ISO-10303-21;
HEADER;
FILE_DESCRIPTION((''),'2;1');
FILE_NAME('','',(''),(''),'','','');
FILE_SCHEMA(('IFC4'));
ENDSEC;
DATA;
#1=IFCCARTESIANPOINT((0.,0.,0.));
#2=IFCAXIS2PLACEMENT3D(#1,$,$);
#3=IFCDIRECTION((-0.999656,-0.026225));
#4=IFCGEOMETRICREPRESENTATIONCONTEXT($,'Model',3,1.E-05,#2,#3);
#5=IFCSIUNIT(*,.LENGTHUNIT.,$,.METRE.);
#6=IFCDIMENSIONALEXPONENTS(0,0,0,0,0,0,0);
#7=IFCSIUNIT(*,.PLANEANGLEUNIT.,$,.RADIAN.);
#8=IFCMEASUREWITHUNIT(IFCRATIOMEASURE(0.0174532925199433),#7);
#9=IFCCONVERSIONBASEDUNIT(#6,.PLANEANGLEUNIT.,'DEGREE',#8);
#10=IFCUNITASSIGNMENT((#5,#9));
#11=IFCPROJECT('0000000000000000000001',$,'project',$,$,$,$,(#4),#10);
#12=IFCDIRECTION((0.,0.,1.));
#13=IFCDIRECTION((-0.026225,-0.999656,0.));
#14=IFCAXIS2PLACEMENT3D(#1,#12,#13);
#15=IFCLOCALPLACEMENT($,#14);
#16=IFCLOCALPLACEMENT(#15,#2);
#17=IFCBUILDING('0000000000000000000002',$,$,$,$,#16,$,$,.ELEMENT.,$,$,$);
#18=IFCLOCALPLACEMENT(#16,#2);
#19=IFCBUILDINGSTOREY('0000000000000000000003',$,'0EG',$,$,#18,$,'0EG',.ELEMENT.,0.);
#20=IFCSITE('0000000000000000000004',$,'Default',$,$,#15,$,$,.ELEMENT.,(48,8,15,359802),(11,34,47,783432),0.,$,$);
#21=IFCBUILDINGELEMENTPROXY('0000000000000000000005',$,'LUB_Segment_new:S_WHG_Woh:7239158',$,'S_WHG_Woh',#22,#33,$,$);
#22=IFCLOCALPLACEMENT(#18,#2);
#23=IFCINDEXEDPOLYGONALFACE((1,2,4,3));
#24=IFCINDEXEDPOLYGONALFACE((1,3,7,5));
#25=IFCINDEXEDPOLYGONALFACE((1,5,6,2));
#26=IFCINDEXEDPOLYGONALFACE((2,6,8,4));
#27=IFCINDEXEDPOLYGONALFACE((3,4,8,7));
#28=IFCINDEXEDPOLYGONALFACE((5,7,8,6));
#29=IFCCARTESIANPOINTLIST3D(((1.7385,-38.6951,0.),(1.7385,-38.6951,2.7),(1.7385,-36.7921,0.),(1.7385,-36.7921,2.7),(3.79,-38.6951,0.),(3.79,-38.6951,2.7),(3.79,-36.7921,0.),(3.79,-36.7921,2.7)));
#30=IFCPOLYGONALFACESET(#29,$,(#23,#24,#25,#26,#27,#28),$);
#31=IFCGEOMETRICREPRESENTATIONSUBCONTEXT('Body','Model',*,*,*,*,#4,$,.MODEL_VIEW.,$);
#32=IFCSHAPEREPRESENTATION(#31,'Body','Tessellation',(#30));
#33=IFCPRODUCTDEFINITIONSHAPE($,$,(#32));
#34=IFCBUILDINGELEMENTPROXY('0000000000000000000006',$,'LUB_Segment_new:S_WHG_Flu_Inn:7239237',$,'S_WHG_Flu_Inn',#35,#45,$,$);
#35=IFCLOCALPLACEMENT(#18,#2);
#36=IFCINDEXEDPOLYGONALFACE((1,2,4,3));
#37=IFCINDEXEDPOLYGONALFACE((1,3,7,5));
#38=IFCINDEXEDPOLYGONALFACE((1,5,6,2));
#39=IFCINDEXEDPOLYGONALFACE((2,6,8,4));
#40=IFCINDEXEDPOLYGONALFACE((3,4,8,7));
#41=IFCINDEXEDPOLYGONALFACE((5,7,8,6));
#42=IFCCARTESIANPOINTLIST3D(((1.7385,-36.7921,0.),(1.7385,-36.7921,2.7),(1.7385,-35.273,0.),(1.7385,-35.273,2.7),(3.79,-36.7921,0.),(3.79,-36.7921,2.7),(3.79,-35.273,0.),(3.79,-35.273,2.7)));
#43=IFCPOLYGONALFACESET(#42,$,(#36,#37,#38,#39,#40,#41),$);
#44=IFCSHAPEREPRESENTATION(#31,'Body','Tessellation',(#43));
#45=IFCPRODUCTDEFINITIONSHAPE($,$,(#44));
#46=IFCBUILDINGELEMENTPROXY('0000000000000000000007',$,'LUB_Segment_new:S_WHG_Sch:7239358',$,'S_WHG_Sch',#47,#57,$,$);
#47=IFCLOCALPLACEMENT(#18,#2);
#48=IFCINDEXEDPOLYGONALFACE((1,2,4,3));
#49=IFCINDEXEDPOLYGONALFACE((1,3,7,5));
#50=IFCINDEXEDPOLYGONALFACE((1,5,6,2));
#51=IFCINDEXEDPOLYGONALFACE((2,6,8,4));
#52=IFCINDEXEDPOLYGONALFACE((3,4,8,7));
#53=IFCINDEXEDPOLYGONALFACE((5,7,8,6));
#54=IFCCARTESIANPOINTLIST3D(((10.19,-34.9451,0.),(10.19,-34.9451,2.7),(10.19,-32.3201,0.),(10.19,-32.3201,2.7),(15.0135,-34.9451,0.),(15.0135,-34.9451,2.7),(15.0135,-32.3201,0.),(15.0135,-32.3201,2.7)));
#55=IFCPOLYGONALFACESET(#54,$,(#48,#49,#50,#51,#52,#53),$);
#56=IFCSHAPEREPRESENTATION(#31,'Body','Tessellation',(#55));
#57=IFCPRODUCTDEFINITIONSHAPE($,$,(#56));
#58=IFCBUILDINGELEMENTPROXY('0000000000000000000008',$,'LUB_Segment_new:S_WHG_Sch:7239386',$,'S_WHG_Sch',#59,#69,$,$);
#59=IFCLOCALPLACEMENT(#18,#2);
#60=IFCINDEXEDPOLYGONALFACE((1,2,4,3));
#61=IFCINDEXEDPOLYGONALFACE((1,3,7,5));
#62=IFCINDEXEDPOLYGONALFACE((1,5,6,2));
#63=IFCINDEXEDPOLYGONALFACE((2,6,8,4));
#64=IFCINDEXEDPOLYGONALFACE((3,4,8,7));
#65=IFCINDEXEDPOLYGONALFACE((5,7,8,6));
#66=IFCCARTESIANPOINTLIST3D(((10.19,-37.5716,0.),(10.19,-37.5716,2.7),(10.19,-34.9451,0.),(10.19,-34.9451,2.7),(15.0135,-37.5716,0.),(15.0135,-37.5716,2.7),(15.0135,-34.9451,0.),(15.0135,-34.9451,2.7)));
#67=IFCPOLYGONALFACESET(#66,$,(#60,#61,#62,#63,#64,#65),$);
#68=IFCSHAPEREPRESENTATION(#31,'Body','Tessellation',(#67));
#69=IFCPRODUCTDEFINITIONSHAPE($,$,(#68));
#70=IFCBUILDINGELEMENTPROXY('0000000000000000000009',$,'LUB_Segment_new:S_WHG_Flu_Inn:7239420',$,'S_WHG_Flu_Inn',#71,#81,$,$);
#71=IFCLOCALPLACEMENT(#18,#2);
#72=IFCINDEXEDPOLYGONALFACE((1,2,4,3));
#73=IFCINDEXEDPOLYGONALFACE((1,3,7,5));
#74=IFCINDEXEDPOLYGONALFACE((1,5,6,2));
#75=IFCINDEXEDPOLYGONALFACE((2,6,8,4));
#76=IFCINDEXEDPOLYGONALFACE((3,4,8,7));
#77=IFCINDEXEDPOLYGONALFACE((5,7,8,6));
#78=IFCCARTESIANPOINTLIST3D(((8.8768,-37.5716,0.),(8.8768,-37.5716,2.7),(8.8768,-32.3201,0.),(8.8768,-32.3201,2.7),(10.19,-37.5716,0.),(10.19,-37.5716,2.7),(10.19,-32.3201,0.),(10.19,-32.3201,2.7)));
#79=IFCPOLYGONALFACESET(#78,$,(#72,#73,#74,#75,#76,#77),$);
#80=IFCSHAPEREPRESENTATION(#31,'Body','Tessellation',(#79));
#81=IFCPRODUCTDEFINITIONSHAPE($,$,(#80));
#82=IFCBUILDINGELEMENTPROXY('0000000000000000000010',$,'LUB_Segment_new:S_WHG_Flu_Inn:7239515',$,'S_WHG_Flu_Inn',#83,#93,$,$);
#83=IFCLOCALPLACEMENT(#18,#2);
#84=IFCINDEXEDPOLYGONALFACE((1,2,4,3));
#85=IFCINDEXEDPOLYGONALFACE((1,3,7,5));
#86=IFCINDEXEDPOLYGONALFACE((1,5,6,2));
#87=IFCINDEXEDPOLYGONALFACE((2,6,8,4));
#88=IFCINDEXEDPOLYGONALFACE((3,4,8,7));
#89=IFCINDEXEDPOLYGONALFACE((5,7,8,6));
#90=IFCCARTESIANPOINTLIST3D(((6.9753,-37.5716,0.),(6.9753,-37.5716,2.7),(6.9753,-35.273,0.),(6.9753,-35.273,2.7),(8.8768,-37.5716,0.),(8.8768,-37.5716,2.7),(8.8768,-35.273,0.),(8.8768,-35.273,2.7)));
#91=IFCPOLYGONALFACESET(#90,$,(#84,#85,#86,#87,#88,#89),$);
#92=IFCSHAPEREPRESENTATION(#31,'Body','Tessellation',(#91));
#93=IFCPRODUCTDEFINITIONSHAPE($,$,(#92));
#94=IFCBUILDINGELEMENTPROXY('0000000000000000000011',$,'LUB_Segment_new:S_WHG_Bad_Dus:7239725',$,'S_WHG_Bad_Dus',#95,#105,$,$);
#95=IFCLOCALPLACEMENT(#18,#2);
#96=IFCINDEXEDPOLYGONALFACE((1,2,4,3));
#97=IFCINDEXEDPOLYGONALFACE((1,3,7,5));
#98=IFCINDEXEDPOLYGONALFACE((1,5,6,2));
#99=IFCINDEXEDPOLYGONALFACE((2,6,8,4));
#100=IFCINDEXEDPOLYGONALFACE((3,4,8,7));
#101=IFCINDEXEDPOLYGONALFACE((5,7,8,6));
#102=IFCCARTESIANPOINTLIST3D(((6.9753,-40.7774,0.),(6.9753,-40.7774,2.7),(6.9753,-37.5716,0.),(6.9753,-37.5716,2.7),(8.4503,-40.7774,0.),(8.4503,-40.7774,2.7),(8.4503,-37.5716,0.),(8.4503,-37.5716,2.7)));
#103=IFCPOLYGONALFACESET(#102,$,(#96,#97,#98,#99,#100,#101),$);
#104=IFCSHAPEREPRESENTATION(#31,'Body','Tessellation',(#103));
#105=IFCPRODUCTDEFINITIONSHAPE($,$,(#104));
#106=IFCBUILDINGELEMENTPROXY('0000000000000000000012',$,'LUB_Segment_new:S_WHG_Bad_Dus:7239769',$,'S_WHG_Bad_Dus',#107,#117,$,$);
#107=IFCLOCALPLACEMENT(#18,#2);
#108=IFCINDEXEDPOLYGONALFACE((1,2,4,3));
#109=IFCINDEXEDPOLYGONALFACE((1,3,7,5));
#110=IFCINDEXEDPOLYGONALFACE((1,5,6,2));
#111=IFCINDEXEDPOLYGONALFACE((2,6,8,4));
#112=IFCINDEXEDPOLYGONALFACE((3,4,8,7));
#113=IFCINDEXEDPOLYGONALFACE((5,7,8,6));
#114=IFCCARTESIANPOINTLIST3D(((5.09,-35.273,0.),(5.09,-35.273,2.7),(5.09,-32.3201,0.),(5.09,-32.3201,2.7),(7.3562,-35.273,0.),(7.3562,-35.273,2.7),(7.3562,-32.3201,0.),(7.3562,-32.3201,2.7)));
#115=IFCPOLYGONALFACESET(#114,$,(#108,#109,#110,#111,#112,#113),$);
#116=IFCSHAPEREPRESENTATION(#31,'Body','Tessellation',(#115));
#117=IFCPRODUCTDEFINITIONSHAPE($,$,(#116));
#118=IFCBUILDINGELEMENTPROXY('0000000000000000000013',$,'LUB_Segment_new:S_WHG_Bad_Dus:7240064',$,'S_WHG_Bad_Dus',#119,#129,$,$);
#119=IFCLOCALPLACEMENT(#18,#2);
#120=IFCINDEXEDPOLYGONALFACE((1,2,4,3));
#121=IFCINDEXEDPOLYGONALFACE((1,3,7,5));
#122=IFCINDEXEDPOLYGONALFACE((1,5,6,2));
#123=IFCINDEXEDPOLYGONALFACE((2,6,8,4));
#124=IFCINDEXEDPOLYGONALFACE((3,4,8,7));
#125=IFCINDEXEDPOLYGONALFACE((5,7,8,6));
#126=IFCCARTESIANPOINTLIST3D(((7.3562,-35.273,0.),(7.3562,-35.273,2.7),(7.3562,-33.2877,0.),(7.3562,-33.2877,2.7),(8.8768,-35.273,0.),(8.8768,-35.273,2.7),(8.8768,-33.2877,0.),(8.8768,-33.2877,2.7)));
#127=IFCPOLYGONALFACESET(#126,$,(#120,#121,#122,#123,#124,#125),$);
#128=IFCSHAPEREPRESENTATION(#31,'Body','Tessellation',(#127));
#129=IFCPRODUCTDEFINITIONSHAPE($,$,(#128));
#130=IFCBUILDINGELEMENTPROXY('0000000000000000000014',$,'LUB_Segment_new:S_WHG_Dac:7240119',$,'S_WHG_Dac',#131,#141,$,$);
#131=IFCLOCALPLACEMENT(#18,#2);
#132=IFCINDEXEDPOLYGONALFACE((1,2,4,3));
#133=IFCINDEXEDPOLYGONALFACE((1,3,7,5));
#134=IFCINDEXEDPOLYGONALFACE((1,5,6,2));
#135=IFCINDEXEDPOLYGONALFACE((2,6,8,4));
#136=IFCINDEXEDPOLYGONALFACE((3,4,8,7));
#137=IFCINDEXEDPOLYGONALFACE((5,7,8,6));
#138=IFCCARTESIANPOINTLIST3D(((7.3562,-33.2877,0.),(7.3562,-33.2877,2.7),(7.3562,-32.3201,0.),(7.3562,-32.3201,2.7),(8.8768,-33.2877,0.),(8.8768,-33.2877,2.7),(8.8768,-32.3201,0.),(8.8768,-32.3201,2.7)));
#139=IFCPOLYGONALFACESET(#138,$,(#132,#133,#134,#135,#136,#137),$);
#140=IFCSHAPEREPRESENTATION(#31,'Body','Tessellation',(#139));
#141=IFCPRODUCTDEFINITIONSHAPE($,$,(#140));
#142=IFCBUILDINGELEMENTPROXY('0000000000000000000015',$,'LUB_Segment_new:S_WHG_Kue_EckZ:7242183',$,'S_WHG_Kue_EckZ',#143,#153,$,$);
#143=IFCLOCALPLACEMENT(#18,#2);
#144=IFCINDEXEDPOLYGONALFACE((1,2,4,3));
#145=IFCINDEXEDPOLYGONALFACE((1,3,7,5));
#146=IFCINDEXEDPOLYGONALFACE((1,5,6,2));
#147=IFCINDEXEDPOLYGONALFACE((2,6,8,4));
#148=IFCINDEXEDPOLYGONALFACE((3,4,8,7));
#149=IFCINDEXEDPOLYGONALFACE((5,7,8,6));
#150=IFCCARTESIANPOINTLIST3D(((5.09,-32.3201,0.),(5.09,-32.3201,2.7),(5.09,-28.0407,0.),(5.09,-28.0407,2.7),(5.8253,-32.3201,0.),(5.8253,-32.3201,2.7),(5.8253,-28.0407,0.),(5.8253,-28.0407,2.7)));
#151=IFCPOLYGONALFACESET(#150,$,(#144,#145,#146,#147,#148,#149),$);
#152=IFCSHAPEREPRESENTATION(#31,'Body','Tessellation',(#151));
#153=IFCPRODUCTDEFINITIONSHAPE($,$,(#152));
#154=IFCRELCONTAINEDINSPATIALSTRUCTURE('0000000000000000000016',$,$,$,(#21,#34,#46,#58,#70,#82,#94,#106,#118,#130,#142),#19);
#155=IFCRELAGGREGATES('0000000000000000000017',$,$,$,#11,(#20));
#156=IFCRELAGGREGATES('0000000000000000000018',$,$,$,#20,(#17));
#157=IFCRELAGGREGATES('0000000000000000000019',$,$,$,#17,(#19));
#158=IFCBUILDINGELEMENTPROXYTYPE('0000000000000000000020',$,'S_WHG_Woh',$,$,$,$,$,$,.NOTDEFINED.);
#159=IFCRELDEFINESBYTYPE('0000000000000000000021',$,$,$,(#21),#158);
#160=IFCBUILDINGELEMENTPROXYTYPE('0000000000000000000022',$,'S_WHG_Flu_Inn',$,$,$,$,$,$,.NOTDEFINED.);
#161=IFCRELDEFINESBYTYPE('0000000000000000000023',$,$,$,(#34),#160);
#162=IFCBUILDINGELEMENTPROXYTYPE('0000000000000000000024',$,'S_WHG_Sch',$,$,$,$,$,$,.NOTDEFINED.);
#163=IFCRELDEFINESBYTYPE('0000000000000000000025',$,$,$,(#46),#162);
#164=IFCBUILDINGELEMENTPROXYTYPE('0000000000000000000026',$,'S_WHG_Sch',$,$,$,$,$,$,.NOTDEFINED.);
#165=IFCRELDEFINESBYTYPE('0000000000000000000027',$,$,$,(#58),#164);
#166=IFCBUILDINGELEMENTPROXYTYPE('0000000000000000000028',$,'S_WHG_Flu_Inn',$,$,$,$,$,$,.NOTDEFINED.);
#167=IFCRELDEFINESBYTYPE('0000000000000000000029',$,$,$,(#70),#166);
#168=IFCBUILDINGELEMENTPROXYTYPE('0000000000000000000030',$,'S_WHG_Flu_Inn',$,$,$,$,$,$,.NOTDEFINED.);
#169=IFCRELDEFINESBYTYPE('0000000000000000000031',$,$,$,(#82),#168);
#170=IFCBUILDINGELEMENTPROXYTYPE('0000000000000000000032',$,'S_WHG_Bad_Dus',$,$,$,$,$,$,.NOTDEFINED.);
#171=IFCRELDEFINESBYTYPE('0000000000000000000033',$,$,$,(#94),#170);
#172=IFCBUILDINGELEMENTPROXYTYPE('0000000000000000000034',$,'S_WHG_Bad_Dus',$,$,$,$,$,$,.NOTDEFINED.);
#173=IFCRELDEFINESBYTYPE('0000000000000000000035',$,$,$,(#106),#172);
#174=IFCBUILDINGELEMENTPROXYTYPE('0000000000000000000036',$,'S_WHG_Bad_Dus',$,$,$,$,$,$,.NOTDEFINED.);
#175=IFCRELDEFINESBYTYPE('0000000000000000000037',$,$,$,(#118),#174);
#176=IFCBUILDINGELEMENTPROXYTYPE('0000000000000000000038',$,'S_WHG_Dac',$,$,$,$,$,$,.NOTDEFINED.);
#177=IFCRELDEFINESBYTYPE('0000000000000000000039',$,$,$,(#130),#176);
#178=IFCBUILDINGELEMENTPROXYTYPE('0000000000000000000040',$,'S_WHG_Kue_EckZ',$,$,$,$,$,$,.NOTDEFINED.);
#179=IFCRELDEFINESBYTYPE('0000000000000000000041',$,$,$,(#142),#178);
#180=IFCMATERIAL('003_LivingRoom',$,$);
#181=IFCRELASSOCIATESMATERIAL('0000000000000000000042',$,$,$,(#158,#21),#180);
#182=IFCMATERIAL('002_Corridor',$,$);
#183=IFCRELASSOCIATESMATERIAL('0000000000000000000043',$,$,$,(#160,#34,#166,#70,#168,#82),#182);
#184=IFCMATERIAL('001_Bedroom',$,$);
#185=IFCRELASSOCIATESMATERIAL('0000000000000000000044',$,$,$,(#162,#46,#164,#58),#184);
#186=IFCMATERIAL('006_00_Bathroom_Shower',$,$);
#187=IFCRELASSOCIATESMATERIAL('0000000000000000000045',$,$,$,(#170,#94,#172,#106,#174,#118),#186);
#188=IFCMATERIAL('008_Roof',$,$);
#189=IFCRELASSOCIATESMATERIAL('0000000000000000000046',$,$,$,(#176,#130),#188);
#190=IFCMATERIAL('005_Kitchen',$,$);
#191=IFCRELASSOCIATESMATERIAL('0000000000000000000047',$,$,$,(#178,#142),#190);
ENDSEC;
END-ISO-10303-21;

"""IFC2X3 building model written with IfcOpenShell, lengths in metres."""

from ifc_helpers import new_model, entity, si_unit, converted_unit, direction, frame, frame_2d, origin, origin_2d_with_axis, place, context, subcontext, project, spatial, rectangle, extrude, source, transform, mapped, material, type_object, type_shapes, element, save


model = new_model("IFC2X3")

# Units and contexts
model_context = context("Model", 3, precision=1e-05, world=origin(), true_north=direction((-0.999656, -0.026225)))
body_context = subcontext(model_context, "Body", "Model", "MODEL_VIEW")
ifc_project = project(units=[si_unit("LENGTHUNIT", "METRE"), converted_unit("PLANEANGLEUNIT", "DEGREE", entity("IfcRatioMeasure", 0.0174532925199433), si_unit("PLANEANGLEUNIT", "RADIAN"), dimensions=[0, 0, 0, 0, 0, 0, 0])], contexts=[model_context])

# Site, building, storey
site_placement = place(None, frame((0.0, 0.0, 0.0), z_axis=(0.0, 0.0, 1.0), x_axis=(-0.026225, -0.999656, 0.0)))
site = spatial("IfcSite", under=ifc_project, at=site_placement, Name="Default", CompositionType="ELEMENT", RefLatitude=(48, 8, 15, 359802), RefLongitude=(11, 34, 47, 783432), RefElevation=0.0)
building_placement = place(site_placement, origin())
building = spatial("IfcBuilding", under=site, at=building_placement, CompositionType="ELEMENT")
storey_placement = place(building_placement, origin())
storey = spatial("IfcBuildingStorey", under=building, at=storey_placement, Name="0EG", LongName="0EG", CompositionType="ELEMENT", Elevation=0.0)

# Building element proxies
ifc_material_1 = material(Name="001_Bedroom")
ifc_material_2 = material(Name="002_Corridor")
ifc_material_3 = material(Name="006_00_Bathroom_Shower")
ifc_material_4 = material(Name="005_Kitchen")
ifc_material_5 = material(Name="003_LivingRoom")
building_element_proxy_type_1 = type_object("IfcBuildingElementProxyType", Name="S_WHG_Woh", PredefinedType="NOTDEFINED", material=ifc_material_5)
shared_shape_1 = source(origin(), body_context, "Body", "SweptSolid", [
    extrude(rectangle(XDim=2.0515, YDim=1.9029, at=origin_2d_with_axis()), frame((0.0, 0.0, 0.0), z_axis=(0.0, 0.0, 1.0), x_axis=(-1.0, 0.0, 0.0)), (0.0, 0.0, 1.0), 2.7),
])
type_shapes(building_element_proxy_type_1, [shared_shape_1])
proxy_1_placement = place(storey_placement, frame((2.7643, -37.7436, 0.0)))
element("IfcBuildingElementProxy", 1, at=proxy_1_placement, inside=storey, type_object=building_element_proxy_type_1, material=ifc_material_5, Name="LUB_Segment_new:S_WHG_Woh:7239158", ObjectType="S_WHG_Woh", context=body_context, shape_type="MappedRepresentation", body=[
    mapped(shared_shape_1, transform((0.0, 0.0, 0.0), scale=1.0)),
])
building_element_proxy_type_2 = type_object("IfcBuildingElementProxyType", Name="S_WHG_Flu_Inn", PredefinedType="NOTDEFINED", material=ifc_material_2)
shared_shape_2 = source(origin(), body_context, "Body", "SweptSolid", [
    extrude(rectangle(XDim=2.0515, YDim=1.5191, at=origin_2d_with_axis()), frame((0.0, 0.0, 0.0), z_axis=(0.0, 0.0, 1.0), x_axis=(-1.0, 0.0, 0.0)), (0.0, 0.0, 1.0), 2.7),
])
type_shapes(building_element_proxy_type_2, [shared_shape_2])
proxy_2_placement = place(storey_placement, frame((2.7643, -36.0326, 0.0)))
element("IfcBuildingElementProxy", 2, at=proxy_2_placement, inside=storey, type_object=building_element_proxy_type_2, material=ifc_material_2, Name="LUB_Segment_new:S_WHG_Flu_Inn:7239237", ObjectType="S_WHG_Flu_Inn", context=body_context, shape_type="MappedRepresentation", body=[
    mapped(shared_shape_2, transform((0.0, 0.0, 0.0), scale=1.0)),
])
building_element_proxy_type_3 = type_object("IfcBuildingElementProxyType", Name="S_WHG_Sch", PredefinedType="NOTDEFINED", material=ifc_material_1)
shared_shape_3 = source(origin(), body_context, "Body", "SweptSolid", [
    extrude(rectangle(XDim=4.8235, YDim=2.625, at=origin_2d_with_axis()), frame((0.0, 0.0, 0.0), z_axis=(0.0, 0.0, 1.0), x_axis=(-1.0, 0.0, 0.0)), (0.0, 0.0, 1.0), 2.7),
])
type_shapes(building_element_proxy_type_3, [shared_shape_3])
proxy_3_placement = place(storey_placement, frame((12.6018, -33.6326, 0.0)))
element("IfcBuildingElementProxy", 3, at=proxy_3_placement, inside=storey, type_object=building_element_proxy_type_3, material=ifc_material_1, Name="LUB_Segment_new:S_WHG_Sch:7239358", ObjectType="S_WHG_Sch", context=body_context, shape_type="MappedRepresentation", body=[
    mapped(shared_shape_3, transform((0.0, 0.0, 0.0), scale=1.0)),
])
building_element_proxy_type_4 = type_object("IfcBuildingElementProxyType", Name="S_WHG_Sch", PredefinedType="NOTDEFINED", material=ifc_material_1)
shared_shape_4 = source(origin(), body_context, "Body", "SweptSolid", [
    extrude(rectangle(XDim=4.8235, YDim=2.6265, at=origin_2d_with_axis()), frame((0.0, 0.0, 0.0), z_axis=(0.0, 0.0, 1.0), x_axis=(-1.0, 0.0, 0.0)), (0.0, 0.0, 1.0), 2.7),
])
type_shapes(building_element_proxy_type_4, [shared_shape_4])
proxy_4_placement = place(storey_placement, frame((12.6018, -36.2583, 0.0)))
element("IfcBuildingElementProxy", 4, at=proxy_4_placement, inside=storey, type_object=building_element_proxy_type_4, material=ifc_material_1, Name="LUB_Segment_new:S_WHG_Sch:7239386", ObjectType="S_WHG_Sch", context=body_context, shape_type="MappedRepresentation", body=[
    mapped(shared_shape_4, transform((0.0, 0.0, 0.0), scale=1.0)),
])
building_element_proxy_type_5 = type_object("IfcBuildingElementProxyType", Name="S_WHG_Flu_Inn", PredefinedType="NOTDEFINED", material=ifc_material_2)
shared_shape_5 = source(origin(), body_context, "Body", "SweptSolid", [
    extrude(rectangle(XDim=1.3132, YDim=5.2515, at=origin_2d_with_axis()), frame((0.0, 0.0, 0.0), z_axis=(0.0, 0.0, 1.0), x_axis=(-1.0, 0.0, 0.0)), (0.0, 0.0, 1.0), 2.7),
])
type_shapes(building_element_proxy_type_5, [shared_shape_5])
proxy_5_placement = place(storey_placement, frame((9.5334, -34.9458, 0.0)))
element("IfcBuildingElementProxy", 5, at=proxy_5_placement, inside=storey, type_object=building_element_proxy_type_5, material=ifc_material_2, Name="LUB_Segment_new:S_WHG_Flu_Inn:7239420", ObjectType="S_WHG_Flu_Inn", context=body_context, shape_type="MappedRepresentation", body=[
    mapped(shared_shape_5, transform((0.0, 0.0, 0.0), scale=1.0)),
])
building_element_proxy_type_6 = type_object("IfcBuildingElementProxyType", Name="S_WHG_Flu_Inn", PredefinedType="NOTDEFINED", material=ifc_material_2)
shared_shape_6 = source(origin(), body_context, "Body", "SweptSolid", [
    extrude(rectangle(XDim=1.9015, YDim=2.2985, at=origin_2d_with_axis()), frame((0.0, 0.0, 0.0), z_axis=(0.0, 0.0, 1.0), x_axis=(-1.0, 0.0, 0.0)), (0.0, 0.0, 1.0), 2.7),
])
type_shapes(building_element_proxy_type_6, [shared_shape_6])
proxy_6_placement = place(storey_placement, frame((7.926, -36.4223, 0.0)))
element("IfcBuildingElementProxy", 6, at=proxy_6_placement, inside=storey, type_object=building_element_proxy_type_6, material=ifc_material_2, Name="LUB_Segment_new:S_WHG_Flu_Inn:7239515", ObjectType="S_WHG_Flu_Inn", context=body_context, shape_type="MappedRepresentation", body=[
    mapped(shared_shape_6, transform((0.0, 0.0, 0.0), scale=1.0)),
])
building_element_proxy_type_7 = type_object("IfcBuildingElementProxyType", Name="S_WHG_Bad_Dus", PredefinedType="NOTDEFINED", material=ifc_material_3)
shared_shape_7 = source(origin(), body_context, "Body", "SweptSolid", [
    extrude(rectangle(XDim=3.2059, YDim=1.475, at=origin_2d_with_axis()), frame((0.0, 0.0, 0.0), z_axis=(0.0, 0.0, 1.0), x_axis=(0.0, 1.0, 0.0)), (0.0, 0.0, 1.0), 2.7),
])
type_shapes(building_element_proxy_type_7, [shared_shape_7])
proxy_7_placement = place(storey_placement, frame((7.7128, -39.1745, 0.0)))
element("IfcBuildingElementProxy", 7, at=proxy_7_placement, inside=storey, type_object=building_element_proxy_type_7, material=ifc_material_3, Name="LUB_Segment_new:S_WHG_Bad_Dus:7239725", ObjectType="S_WHG_Bad_Dus", context=body_context, shape_type="MappedRepresentation", body=[
    mapped(shared_shape_7, transform((0.0, 0.0, 0.0), scale=1.0)),
])
building_element_proxy_type_8 = type_object("IfcBuildingElementProxyType", Name="S_WHG_Bad_Dus", PredefinedType="NOTDEFINED", material=ifc_material_3)
shared_shape_8 = source(origin(), body_context, "Body", "SweptSolid", [
    extrude(rectangle(XDim=2.9529, YDim=2.2662, at=origin_2d_with_axis()), frame((0.0, 0.0, 0.0), z_axis=(0.0, 0.0, 1.0), x_axis=(0.0, 1.0, 0.0)), (0.0, 0.0, 1.0), 2.7),
])
type_shapes(building_element_proxy_type_8, [shared_shape_8])
proxy_8_placement = place(storey_placement, frame((6.2231, -33.7966, 0.0)))
element("IfcBuildingElementProxy", 8, at=proxy_8_placement, inside=storey, type_object=building_element_proxy_type_8, material=ifc_material_3, Name="LUB_Segment_new:S_WHG_Bad_Dus:7239769", ObjectType="S_WHG_Bad_Dus", context=body_context, shape_type="MappedRepresentation", body=[
    mapped(shared_shape_8, transform((0.0, 0.0, 0.0), scale=1.0)),
])
building_element_proxy_type_9 = type_object("IfcBuildingElementProxyType", Name="S_WHG_Bad_Dus", PredefinedType="NOTDEFINED", material=ifc_material_3)
shared_shape_9 = source(origin(), body_context, "Body", "SweptSolid", [
    extrude(rectangle(XDim=1.9853, YDim=1.5206, at=origin_2d_with_axis()), frame((0.0, 0.0, 0.0), z_axis=(0.0, 0.0, 1.0), x_axis=(0.0, 1.0, 0.0)), (0.0, 0.0, 1.0), 2.7),
])
type_shapes(building_element_proxy_type_9, [shared_shape_9])
proxy_9_placement = place(storey_placement, frame((8.1165, -34.2804, 0.0)))
element("IfcBuildingElementProxy", 9, at=proxy_9_placement, inside=storey, type_object=building_element_proxy_type_9, material=ifc_material_3, Name="LUB_Segment_new:S_WHG_Bad_Dus:7240064", ObjectType="S_WHG_Bad_Dus", context=body_context, shape_type="MappedRepresentation", body=[
    mapped(shared_shape_9, transform((0.0, 0.0, 0.0), scale=1.0)),
])
ifc_material_6 = material(Name="008_Roof")
building_element_proxy_type_10 = type_object("IfcBuildingElementProxyType", Name="S_WHG_Dac", PredefinedType="NOTDEFINED", material=ifc_material_6)
shared_shape_10 = source(origin(), body_context, "Body", "SweptSolid", [
    extrude(rectangle(XDim=0.9676, YDim=1.5206, at=frame_2d((0.0, 0.0), x_axis=(1.0, 0.0))), frame((0.0, 0.0, 0.0), z_axis=(0.0, 0.0, 1.0), x_axis=(0.0, 1.0, 0.0)), (0.0, 0.0, 1.0), 2.7),
])
type_shapes(building_element_proxy_type_10, [shared_shape_10])
proxy_10_placement = place(storey_placement, frame((8.1165, -32.8039, 0.0)))
element("IfcBuildingElementProxy", 10, at=proxy_10_placement, inside=storey, type_object=building_element_proxy_type_10, material=ifc_material_6, Name="LUB_Segment_new:S_WHG_Dac:7240119", ObjectType="S_WHG_Dac", context=body_context, shape_type="MappedRepresentation", body=[
    mapped(shared_shape_10, transform((0.0, 0.0, 0.0), scale=1.0)),
])
building_element_proxy_type_11 = type_object("IfcBuildingElementProxyType", Name="S_WHG_Kue_EckZ", PredefinedType="NOTDEFINED", material=ifc_material_4)
shared_shape_11 = source(origin(), body_context, "Body", "SweptSolid", [
    extrude(rectangle(XDim=4.2794, YDim=0.7353, at=origin_2d_with_axis()), frame((0.0, 0.0, 0.0), z_axis=(0.0, 0.0, 1.0), x_axis=(0.0, 1.0, 0.0)), (0.0, 0.0, 1.0), 2.7),
])
type_shapes(building_element_proxy_type_11, [shared_shape_11])
proxy_11_placement = place(storey_placement, frame((5.4577, -30.1804, 0.0)))
element("IfcBuildingElementProxy", 11, at=proxy_11_placement, inside=storey, type_object=building_element_proxy_type_11, material=ifc_material_4, Name="LUB_Segment_new:S_WHG_Kue_EckZ:7242183", ObjectType="S_WHG_Kue_EckZ", context=body_context, shape_type="MappedRepresentation", body=[
    mapped(shared_shape_11, transform((0.0, 0.0, 0.0), scale=1.0)),
])

save(model, "model.ifc")
